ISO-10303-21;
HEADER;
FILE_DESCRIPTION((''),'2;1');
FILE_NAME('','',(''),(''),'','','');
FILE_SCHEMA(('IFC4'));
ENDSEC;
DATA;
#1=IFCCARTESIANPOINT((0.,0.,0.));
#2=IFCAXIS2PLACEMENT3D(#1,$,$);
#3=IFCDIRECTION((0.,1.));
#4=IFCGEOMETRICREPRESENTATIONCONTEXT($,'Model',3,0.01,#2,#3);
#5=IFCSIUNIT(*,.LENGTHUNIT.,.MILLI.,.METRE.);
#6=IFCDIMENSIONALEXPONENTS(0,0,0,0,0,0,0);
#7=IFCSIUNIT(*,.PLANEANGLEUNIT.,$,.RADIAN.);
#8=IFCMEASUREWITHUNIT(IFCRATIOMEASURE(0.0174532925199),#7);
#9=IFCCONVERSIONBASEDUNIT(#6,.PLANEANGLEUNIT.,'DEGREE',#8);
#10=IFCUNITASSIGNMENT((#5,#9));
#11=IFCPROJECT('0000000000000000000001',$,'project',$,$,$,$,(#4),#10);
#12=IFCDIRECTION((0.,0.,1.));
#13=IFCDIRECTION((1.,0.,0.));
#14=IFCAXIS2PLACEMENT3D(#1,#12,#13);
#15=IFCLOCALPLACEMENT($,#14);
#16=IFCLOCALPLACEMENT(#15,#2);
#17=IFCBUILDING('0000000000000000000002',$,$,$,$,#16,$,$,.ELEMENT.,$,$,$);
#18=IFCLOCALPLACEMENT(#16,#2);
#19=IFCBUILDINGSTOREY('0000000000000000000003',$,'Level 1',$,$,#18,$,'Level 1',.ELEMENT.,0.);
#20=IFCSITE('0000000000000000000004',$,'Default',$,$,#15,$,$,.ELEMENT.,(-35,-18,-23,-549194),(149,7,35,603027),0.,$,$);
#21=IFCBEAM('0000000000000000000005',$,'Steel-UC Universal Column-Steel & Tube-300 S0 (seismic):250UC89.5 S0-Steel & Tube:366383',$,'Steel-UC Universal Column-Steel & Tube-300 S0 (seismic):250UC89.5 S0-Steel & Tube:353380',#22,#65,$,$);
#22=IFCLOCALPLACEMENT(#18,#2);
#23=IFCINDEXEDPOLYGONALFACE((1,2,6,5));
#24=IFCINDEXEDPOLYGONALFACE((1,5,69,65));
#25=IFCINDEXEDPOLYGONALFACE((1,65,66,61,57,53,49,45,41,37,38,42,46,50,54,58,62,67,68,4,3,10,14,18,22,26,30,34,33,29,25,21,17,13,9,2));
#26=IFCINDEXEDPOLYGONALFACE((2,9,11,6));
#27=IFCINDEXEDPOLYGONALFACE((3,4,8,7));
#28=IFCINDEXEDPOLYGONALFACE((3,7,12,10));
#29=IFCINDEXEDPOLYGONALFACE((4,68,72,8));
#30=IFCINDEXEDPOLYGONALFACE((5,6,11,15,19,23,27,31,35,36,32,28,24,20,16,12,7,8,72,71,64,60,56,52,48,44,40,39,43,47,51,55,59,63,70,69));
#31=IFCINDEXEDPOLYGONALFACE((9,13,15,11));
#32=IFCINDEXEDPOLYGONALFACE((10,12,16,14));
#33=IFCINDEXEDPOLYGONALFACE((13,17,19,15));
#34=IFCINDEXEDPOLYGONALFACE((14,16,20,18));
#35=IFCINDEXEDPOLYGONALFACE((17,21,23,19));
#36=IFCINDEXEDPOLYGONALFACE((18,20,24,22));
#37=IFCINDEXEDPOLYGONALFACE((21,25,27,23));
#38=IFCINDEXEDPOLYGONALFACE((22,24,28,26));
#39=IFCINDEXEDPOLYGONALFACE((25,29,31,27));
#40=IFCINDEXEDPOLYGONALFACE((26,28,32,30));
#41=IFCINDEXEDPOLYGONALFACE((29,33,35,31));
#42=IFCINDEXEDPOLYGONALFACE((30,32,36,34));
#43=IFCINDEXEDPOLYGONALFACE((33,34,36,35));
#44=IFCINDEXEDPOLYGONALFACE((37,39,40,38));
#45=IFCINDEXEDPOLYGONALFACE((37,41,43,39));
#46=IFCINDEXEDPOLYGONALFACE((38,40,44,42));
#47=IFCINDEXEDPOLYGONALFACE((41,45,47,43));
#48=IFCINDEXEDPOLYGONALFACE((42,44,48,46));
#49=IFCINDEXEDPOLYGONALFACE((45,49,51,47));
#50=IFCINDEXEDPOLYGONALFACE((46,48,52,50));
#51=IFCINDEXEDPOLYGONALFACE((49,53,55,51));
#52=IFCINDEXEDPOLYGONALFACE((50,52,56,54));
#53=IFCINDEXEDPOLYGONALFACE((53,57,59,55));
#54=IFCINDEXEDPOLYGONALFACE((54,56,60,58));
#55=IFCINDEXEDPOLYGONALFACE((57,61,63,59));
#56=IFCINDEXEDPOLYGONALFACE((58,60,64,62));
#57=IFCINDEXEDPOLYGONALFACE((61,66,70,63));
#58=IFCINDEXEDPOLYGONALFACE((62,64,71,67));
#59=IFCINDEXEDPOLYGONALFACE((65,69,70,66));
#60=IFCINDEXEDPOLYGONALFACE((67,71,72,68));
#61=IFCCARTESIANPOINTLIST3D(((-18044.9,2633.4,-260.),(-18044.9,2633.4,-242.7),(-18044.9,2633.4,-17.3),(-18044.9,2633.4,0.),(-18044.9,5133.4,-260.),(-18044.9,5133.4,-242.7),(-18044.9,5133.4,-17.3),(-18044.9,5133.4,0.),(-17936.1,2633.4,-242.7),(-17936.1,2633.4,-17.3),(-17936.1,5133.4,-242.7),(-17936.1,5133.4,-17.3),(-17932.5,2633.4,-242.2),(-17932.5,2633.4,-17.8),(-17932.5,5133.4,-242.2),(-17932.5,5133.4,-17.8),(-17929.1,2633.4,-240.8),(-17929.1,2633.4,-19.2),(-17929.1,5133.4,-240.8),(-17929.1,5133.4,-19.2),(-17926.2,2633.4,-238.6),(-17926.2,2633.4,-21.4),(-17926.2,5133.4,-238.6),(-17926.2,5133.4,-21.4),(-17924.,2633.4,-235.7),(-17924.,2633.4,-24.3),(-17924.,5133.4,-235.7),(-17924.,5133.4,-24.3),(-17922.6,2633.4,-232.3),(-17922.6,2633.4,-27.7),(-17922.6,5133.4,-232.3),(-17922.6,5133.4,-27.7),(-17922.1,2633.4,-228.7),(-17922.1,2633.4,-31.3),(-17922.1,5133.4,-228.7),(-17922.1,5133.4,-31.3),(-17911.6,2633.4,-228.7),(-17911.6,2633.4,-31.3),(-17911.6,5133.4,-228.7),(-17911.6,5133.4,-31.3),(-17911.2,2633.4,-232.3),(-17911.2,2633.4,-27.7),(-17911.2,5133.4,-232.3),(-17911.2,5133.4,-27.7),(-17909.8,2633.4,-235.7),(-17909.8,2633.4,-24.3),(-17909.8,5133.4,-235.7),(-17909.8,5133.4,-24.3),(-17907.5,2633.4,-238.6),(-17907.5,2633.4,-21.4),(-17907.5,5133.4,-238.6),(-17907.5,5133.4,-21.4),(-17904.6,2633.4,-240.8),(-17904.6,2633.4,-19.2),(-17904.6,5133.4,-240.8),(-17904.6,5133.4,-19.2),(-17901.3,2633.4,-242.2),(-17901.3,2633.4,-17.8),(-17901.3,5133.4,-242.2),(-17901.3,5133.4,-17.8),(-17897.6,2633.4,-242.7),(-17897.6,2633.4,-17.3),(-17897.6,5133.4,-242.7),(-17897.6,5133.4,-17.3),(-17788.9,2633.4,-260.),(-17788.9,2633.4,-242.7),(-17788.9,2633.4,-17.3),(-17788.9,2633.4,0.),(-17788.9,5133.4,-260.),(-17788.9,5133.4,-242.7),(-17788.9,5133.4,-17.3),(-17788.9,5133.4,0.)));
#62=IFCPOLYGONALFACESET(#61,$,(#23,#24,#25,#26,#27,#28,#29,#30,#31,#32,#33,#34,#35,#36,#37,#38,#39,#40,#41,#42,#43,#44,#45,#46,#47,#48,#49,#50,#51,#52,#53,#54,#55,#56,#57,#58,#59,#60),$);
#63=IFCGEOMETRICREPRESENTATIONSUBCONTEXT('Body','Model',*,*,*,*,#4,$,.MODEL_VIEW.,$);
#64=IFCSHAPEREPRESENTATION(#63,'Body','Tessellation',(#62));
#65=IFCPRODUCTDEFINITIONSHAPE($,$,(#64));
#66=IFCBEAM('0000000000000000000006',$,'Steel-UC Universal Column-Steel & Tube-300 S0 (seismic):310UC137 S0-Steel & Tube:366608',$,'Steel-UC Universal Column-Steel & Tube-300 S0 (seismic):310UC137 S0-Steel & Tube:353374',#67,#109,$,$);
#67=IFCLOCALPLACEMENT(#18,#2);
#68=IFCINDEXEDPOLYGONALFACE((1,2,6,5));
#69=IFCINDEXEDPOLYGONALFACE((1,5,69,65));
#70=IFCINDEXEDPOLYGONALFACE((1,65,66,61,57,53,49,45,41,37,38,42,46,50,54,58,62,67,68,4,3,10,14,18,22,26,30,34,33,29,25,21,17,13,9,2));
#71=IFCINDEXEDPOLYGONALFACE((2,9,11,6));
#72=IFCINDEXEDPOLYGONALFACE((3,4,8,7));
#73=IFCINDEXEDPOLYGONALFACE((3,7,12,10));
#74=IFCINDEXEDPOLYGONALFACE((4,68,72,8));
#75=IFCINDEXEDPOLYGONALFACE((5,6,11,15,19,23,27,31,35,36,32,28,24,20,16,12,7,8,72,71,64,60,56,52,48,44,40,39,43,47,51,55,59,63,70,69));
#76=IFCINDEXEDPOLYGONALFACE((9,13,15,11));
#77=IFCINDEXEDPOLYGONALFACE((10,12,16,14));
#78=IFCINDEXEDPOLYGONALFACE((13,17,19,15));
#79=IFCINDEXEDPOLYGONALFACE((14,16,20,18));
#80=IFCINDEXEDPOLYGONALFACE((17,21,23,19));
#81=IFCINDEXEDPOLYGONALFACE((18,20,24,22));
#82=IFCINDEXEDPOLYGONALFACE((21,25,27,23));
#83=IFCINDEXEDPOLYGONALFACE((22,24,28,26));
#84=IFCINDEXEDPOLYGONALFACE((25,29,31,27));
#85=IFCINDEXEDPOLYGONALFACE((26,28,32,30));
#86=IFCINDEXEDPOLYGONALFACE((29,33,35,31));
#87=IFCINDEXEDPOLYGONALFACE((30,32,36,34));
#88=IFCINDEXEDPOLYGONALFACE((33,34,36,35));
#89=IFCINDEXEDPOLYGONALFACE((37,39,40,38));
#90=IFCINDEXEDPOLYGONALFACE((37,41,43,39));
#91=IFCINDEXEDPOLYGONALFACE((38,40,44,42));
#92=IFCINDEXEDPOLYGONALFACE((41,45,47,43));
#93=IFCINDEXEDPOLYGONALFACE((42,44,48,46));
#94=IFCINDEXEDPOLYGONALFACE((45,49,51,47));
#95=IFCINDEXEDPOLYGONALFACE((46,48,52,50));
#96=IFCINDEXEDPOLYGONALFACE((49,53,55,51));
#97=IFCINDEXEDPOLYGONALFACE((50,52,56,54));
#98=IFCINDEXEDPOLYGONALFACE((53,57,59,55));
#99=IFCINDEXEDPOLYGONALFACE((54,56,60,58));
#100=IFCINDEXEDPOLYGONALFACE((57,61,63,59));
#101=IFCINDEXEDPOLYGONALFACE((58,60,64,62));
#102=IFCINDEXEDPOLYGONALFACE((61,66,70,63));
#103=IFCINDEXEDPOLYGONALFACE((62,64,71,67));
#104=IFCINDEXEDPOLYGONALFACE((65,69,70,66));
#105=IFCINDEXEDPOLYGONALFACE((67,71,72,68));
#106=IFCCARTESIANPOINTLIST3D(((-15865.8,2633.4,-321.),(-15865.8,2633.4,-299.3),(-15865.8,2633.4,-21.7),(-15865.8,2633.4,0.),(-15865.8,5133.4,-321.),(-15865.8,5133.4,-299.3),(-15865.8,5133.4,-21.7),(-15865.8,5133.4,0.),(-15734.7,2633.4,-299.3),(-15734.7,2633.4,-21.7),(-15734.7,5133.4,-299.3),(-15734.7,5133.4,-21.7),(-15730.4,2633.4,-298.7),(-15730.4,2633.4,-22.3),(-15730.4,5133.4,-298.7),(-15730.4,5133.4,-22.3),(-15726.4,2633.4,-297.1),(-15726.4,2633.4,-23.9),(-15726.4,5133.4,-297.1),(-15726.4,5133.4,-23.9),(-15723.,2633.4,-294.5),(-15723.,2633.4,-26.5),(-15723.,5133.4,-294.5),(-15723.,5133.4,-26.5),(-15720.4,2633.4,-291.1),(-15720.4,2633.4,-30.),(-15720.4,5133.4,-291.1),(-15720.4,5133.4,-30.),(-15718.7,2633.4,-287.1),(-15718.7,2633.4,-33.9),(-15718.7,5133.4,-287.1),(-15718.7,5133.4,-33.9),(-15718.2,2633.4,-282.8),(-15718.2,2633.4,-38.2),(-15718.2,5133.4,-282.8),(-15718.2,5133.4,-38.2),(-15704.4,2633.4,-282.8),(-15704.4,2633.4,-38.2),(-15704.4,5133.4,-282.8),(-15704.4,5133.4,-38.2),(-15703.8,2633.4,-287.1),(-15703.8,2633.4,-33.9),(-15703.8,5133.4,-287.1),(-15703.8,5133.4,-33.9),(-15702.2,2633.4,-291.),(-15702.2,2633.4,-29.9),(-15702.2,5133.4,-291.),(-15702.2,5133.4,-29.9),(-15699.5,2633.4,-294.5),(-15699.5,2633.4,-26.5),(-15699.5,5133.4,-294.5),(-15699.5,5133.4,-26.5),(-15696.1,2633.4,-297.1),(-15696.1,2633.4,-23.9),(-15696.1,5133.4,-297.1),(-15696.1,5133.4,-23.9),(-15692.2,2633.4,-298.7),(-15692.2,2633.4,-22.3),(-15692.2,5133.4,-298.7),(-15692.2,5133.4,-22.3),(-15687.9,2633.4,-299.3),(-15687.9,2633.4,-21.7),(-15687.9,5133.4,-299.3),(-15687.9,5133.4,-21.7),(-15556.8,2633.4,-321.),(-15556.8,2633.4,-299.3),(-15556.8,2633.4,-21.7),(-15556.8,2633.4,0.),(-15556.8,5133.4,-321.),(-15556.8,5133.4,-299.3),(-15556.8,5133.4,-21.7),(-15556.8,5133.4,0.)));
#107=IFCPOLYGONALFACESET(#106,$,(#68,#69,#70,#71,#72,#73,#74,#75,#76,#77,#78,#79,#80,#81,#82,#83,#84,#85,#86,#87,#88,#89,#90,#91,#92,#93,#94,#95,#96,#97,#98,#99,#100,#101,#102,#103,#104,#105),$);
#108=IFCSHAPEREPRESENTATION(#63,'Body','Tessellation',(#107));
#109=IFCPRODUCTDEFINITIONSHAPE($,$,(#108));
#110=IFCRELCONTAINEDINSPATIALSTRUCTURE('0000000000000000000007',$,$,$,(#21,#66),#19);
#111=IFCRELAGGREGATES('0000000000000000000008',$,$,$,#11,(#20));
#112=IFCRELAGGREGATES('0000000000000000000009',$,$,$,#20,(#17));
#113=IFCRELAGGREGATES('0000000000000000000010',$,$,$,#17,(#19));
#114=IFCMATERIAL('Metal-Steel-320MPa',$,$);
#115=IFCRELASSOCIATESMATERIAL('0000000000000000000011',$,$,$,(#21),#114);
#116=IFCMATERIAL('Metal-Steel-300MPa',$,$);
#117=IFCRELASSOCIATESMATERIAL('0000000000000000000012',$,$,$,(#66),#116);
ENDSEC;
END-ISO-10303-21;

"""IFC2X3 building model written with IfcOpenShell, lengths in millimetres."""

from ifc_helpers import new_model, entity, si_unit, converted_unit, direction, frame, frame_2d, origin, origin_with_axes, place, context, subcontext, project, spatial, polyline, circle_curve, parameter, trimmed, segment, composite_curve, outline, extrude, material, element, save


model = new_model("IFC2X3")

# Units and contexts
model_context = context("Model", 3, precision=0.01, world=origin(), true_north=direction((0.0, 1.0)))
body_context = subcontext(model_context, "Body", "Model", "MODEL_VIEW")
ifc_project = project(units=[si_unit("LENGTHUNIT", "METRE", prefix="MILLI"), converted_unit("PLANEANGLEUNIT", "DEGREE", entity("IfcRatioMeasure", 0.0174532925199), si_unit("PLANEANGLEUNIT", "RADIAN"), dimensions=[0, 0, 0, 0, 0, 0, 0])], contexts=[model_context])

# Site, building, storey
site_placement = place(None, origin_with_axes())
site = spatial("IfcSite", under=ifc_project, at=site_placement, Name="Default", CompositionType="ELEMENT", RefLatitude=(-35, -18, -23, -549194), RefLongitude=(149, 7, 35, 603027), RefElevation=0.0)
building_placement = place(site_placement, origin())
building = spatial("IfcBuilding", under=site, at=building_placement, CompositionType="ELEMENT")
storey_placement = place(building_placement, origin())
storey = spatial("IfcBuildingStorey", under=building, at=storey_placement, Name="Level 1", LongName="Level 1", CompositionType="ELEMENT", Elevation=0.0)

# Beams
ifc_material_1 = material(Name="Metal-Steel-320MPa")
beam_1_placement = place(storey_placement, frame((-17916.9, 5133.4, 0.0), z_axis=(0.0, 0.0, 1.0), x_axis=(0.0, -1.0, 0.0)))
element("IfcBeam", 1, at=beam_1_placement, inside=storey, material=ifc_material_1, Name="Steel-UC Universal Column-Steel & Tube-300 S0 (seismic):250UC89.5 S0-Steel & Tube:366383", ObjectType="Steel-UC Universal Column-Steel & Tube-300 S0 (seismic):250UC89.5 S0-Steel & Tube:353380", context=body_context, shape_type="SweptSolid", body=[
    extrude(outline(composite_curve([segment(polyline([(112.7, -128.0), (130.0, -128.0)]), True, "CONTINUOUS"), segment(polyline([(130.0, -128.0), (130.0, 128.0)]), True, "CONTINUOUS"), segment(polyline([(130.0, 128.0), (112.7, 128.0)]), True, "CONTINUOUS"), segment(polyline([(112.7, 128.0), (112.7, 19.2)]), True, "CONTINUOUS"), segment(trimmed(circle_curve(frame_2d((98.7, 19.2), x_axis=(1.0, 0.0)), 14.0), [parameter(270.0)], [parameter(0.0)], True, "PARAMETER"), False, "CONTINUOUS"), segment(polyline([(98.7, 5.2), (-98.7, 5.2)]), True, "CONTINUOUS"), segment(trimmed(circle_curve(frame_2d((-98.7, 19.2), x_axis=(0.0, -1.0)), 14.0), [parameter(270.0)], [parameter(0.0)], True, "PARAMETER"), False, "CONTINUOUS"), segment(polyline([(-112.7, 19.2), (-112.7, 128.0)]), True, "CONTINUOUS"), segment(polyline([(-112.7, 128.0), (-130.0, 128.0)]), True, "CONTINUOUS"), segment(polyline([(-130.0, 128.0), (-130.0, -128.0)]), True, "CONTINUOUS"), segment(polyline([(-130.0, -128.0), (-112.7, -128.0)]), True, "CONTINUOUS"), segment(polyline([(-112.7, -128.0), (-112.7, -19.2)]), True, "CONTINUOUS"), segment(trimmed(circle_curve(frame_2d((-98.7, -19.2), x_axis=(-1.0, 0.0)), 14.0), [parameter(270.0)], [parameter(0.0)], True, "PARAMETER"), False, "CONTINUOUS"), segment(polyline([(-98.7, -5.2), (98.7, -5.2)]), True, "CONTINUOUS"), segment(trimmed(circle_curve(frame_2d((98.7, -19.2), x_axis=(0.0, 1.0)), 14.0), [parameter(270.0)], [parameter(0.0)], True, "PARAMETER"), False, "CONTINUOUS"), segment(polyline([(112.7, -19.2), (112.7, -128.0)]), True, "CONTINUOUS")], self_intersect=False)), frame((0.0, 0.0, -130.0), z_axis=(1.0, 0.0, 0.0), x_axis=(0.0, 0.0, -1.0)), (0.0, 0.0, 1.0), 2500.0),
])
ifc_material_2 = material(Name="Metal-Steel-300MPa")
beam_2_placement = place(storey_placement, frame((-15711.3, 5133.4, 0.0), z_axis=(0.0, 0.0, 1.0), x_axis=(0.0, -1.0, 0.0)))
element("IfcBeam", 2, at=beam_2_placement, inside=storey, material=ifc_material_2, Name="Steel-UC Universal Column-Steel & Tube-300 S0 (seismic):310UC137 S0-Steel & Tube:366608", ObjectType="Steel-UC Universal Column-Steel & Tube-300 S0 (seismic):310UC137 S0-Steel & Tube:353374", context=body_context, shape_type="SweptSolid", body=[
    extrude(outline(composite_curve([segment(polyline([(138.8, -154.5), (160.5, -154.5)]), True, "CONTINUOUS"), segment(polyline([(160.5, -154.5), (160.5, 154.5)]), True, "CONTINUOUS"), segment(polyline([(160.5, 154.5), (138.8, 154.5)]), True, "CONTINUOUS"), segment(polyline([(138.8, 154.5), (138.8, 23.4)]), True, "CONTINUOUS"), segment(trimmed(circle_curve(frame_2d((122.3, 23.4), x_axis=(1.0, 0.0)), 16.5), [parameter(270.0)], [parameter(0.0)], True, "PARAMETER"), False, "CONTINUOUS"), segment(polyline([(122.3, 6.9), (-122.3, 6.9)]), True, "CONTINUOUS"), segment(trimmed(circle_curve(frame_2d((-122.3, 23.4), x_axis=(0.0, -1.0)), 16.5), [parameter(270.0)], [parameter(0.0)], True, "PARAMETER"), False, "CONTINUOUS"), segment(polyline([(-138.8, 23.4), (-138.8, 154.5)]), True, "CONTINUOUS"), segment(polyline([(-138.8, 154.5), (-160.5, 154.5)]), True, "CONTINUOUS"), segment(polyline([(-160.5, 154.5), (-160.5, -154.5)]), True, "CONTINUOUS"), segment(polyline([(-160.5, -154.5), (-138.8, -154.5)]), True, "CONTINUOUS"), segment(polyline([(-138.8, -154.5), (-138.8, -23.4)]), True, "CONTINUOUS"), segment(trimmed(circle_curve(frame_2d((-122.3, -23.4), x_axis=(-1.0, 0.0)), 16.5), [parameter(270.0)], [parameter(0.0)], True, "PARAMETER"), False, "CONTINUOUS"), segment(polyline([(-122.3, -6.9), (122.3, -6.9)]), True, "CONTINUOUS"), segment(trimmed(circle_curve(frame_2d((122.3, -23.4), x_axis=(0.0, 1.0)), 16.5), [parameter(270.0)], [parameter(0.0)], True, "PARAMETER"), False, "CONTINUOUS"), segment(polyline([(138.8, -23.4), (138.8, -154.5)]), True, "CONTINUOUS")], self_intersect=False)), frame((0.0, 0.0, -160.5), z_axis=(1.0, 0.0, 0.0), x_axis=(0.0, 0.0, -1.0)), (0.0, 0.0, 1.0), 2500.0),
])

save(model, "model.ifc")
